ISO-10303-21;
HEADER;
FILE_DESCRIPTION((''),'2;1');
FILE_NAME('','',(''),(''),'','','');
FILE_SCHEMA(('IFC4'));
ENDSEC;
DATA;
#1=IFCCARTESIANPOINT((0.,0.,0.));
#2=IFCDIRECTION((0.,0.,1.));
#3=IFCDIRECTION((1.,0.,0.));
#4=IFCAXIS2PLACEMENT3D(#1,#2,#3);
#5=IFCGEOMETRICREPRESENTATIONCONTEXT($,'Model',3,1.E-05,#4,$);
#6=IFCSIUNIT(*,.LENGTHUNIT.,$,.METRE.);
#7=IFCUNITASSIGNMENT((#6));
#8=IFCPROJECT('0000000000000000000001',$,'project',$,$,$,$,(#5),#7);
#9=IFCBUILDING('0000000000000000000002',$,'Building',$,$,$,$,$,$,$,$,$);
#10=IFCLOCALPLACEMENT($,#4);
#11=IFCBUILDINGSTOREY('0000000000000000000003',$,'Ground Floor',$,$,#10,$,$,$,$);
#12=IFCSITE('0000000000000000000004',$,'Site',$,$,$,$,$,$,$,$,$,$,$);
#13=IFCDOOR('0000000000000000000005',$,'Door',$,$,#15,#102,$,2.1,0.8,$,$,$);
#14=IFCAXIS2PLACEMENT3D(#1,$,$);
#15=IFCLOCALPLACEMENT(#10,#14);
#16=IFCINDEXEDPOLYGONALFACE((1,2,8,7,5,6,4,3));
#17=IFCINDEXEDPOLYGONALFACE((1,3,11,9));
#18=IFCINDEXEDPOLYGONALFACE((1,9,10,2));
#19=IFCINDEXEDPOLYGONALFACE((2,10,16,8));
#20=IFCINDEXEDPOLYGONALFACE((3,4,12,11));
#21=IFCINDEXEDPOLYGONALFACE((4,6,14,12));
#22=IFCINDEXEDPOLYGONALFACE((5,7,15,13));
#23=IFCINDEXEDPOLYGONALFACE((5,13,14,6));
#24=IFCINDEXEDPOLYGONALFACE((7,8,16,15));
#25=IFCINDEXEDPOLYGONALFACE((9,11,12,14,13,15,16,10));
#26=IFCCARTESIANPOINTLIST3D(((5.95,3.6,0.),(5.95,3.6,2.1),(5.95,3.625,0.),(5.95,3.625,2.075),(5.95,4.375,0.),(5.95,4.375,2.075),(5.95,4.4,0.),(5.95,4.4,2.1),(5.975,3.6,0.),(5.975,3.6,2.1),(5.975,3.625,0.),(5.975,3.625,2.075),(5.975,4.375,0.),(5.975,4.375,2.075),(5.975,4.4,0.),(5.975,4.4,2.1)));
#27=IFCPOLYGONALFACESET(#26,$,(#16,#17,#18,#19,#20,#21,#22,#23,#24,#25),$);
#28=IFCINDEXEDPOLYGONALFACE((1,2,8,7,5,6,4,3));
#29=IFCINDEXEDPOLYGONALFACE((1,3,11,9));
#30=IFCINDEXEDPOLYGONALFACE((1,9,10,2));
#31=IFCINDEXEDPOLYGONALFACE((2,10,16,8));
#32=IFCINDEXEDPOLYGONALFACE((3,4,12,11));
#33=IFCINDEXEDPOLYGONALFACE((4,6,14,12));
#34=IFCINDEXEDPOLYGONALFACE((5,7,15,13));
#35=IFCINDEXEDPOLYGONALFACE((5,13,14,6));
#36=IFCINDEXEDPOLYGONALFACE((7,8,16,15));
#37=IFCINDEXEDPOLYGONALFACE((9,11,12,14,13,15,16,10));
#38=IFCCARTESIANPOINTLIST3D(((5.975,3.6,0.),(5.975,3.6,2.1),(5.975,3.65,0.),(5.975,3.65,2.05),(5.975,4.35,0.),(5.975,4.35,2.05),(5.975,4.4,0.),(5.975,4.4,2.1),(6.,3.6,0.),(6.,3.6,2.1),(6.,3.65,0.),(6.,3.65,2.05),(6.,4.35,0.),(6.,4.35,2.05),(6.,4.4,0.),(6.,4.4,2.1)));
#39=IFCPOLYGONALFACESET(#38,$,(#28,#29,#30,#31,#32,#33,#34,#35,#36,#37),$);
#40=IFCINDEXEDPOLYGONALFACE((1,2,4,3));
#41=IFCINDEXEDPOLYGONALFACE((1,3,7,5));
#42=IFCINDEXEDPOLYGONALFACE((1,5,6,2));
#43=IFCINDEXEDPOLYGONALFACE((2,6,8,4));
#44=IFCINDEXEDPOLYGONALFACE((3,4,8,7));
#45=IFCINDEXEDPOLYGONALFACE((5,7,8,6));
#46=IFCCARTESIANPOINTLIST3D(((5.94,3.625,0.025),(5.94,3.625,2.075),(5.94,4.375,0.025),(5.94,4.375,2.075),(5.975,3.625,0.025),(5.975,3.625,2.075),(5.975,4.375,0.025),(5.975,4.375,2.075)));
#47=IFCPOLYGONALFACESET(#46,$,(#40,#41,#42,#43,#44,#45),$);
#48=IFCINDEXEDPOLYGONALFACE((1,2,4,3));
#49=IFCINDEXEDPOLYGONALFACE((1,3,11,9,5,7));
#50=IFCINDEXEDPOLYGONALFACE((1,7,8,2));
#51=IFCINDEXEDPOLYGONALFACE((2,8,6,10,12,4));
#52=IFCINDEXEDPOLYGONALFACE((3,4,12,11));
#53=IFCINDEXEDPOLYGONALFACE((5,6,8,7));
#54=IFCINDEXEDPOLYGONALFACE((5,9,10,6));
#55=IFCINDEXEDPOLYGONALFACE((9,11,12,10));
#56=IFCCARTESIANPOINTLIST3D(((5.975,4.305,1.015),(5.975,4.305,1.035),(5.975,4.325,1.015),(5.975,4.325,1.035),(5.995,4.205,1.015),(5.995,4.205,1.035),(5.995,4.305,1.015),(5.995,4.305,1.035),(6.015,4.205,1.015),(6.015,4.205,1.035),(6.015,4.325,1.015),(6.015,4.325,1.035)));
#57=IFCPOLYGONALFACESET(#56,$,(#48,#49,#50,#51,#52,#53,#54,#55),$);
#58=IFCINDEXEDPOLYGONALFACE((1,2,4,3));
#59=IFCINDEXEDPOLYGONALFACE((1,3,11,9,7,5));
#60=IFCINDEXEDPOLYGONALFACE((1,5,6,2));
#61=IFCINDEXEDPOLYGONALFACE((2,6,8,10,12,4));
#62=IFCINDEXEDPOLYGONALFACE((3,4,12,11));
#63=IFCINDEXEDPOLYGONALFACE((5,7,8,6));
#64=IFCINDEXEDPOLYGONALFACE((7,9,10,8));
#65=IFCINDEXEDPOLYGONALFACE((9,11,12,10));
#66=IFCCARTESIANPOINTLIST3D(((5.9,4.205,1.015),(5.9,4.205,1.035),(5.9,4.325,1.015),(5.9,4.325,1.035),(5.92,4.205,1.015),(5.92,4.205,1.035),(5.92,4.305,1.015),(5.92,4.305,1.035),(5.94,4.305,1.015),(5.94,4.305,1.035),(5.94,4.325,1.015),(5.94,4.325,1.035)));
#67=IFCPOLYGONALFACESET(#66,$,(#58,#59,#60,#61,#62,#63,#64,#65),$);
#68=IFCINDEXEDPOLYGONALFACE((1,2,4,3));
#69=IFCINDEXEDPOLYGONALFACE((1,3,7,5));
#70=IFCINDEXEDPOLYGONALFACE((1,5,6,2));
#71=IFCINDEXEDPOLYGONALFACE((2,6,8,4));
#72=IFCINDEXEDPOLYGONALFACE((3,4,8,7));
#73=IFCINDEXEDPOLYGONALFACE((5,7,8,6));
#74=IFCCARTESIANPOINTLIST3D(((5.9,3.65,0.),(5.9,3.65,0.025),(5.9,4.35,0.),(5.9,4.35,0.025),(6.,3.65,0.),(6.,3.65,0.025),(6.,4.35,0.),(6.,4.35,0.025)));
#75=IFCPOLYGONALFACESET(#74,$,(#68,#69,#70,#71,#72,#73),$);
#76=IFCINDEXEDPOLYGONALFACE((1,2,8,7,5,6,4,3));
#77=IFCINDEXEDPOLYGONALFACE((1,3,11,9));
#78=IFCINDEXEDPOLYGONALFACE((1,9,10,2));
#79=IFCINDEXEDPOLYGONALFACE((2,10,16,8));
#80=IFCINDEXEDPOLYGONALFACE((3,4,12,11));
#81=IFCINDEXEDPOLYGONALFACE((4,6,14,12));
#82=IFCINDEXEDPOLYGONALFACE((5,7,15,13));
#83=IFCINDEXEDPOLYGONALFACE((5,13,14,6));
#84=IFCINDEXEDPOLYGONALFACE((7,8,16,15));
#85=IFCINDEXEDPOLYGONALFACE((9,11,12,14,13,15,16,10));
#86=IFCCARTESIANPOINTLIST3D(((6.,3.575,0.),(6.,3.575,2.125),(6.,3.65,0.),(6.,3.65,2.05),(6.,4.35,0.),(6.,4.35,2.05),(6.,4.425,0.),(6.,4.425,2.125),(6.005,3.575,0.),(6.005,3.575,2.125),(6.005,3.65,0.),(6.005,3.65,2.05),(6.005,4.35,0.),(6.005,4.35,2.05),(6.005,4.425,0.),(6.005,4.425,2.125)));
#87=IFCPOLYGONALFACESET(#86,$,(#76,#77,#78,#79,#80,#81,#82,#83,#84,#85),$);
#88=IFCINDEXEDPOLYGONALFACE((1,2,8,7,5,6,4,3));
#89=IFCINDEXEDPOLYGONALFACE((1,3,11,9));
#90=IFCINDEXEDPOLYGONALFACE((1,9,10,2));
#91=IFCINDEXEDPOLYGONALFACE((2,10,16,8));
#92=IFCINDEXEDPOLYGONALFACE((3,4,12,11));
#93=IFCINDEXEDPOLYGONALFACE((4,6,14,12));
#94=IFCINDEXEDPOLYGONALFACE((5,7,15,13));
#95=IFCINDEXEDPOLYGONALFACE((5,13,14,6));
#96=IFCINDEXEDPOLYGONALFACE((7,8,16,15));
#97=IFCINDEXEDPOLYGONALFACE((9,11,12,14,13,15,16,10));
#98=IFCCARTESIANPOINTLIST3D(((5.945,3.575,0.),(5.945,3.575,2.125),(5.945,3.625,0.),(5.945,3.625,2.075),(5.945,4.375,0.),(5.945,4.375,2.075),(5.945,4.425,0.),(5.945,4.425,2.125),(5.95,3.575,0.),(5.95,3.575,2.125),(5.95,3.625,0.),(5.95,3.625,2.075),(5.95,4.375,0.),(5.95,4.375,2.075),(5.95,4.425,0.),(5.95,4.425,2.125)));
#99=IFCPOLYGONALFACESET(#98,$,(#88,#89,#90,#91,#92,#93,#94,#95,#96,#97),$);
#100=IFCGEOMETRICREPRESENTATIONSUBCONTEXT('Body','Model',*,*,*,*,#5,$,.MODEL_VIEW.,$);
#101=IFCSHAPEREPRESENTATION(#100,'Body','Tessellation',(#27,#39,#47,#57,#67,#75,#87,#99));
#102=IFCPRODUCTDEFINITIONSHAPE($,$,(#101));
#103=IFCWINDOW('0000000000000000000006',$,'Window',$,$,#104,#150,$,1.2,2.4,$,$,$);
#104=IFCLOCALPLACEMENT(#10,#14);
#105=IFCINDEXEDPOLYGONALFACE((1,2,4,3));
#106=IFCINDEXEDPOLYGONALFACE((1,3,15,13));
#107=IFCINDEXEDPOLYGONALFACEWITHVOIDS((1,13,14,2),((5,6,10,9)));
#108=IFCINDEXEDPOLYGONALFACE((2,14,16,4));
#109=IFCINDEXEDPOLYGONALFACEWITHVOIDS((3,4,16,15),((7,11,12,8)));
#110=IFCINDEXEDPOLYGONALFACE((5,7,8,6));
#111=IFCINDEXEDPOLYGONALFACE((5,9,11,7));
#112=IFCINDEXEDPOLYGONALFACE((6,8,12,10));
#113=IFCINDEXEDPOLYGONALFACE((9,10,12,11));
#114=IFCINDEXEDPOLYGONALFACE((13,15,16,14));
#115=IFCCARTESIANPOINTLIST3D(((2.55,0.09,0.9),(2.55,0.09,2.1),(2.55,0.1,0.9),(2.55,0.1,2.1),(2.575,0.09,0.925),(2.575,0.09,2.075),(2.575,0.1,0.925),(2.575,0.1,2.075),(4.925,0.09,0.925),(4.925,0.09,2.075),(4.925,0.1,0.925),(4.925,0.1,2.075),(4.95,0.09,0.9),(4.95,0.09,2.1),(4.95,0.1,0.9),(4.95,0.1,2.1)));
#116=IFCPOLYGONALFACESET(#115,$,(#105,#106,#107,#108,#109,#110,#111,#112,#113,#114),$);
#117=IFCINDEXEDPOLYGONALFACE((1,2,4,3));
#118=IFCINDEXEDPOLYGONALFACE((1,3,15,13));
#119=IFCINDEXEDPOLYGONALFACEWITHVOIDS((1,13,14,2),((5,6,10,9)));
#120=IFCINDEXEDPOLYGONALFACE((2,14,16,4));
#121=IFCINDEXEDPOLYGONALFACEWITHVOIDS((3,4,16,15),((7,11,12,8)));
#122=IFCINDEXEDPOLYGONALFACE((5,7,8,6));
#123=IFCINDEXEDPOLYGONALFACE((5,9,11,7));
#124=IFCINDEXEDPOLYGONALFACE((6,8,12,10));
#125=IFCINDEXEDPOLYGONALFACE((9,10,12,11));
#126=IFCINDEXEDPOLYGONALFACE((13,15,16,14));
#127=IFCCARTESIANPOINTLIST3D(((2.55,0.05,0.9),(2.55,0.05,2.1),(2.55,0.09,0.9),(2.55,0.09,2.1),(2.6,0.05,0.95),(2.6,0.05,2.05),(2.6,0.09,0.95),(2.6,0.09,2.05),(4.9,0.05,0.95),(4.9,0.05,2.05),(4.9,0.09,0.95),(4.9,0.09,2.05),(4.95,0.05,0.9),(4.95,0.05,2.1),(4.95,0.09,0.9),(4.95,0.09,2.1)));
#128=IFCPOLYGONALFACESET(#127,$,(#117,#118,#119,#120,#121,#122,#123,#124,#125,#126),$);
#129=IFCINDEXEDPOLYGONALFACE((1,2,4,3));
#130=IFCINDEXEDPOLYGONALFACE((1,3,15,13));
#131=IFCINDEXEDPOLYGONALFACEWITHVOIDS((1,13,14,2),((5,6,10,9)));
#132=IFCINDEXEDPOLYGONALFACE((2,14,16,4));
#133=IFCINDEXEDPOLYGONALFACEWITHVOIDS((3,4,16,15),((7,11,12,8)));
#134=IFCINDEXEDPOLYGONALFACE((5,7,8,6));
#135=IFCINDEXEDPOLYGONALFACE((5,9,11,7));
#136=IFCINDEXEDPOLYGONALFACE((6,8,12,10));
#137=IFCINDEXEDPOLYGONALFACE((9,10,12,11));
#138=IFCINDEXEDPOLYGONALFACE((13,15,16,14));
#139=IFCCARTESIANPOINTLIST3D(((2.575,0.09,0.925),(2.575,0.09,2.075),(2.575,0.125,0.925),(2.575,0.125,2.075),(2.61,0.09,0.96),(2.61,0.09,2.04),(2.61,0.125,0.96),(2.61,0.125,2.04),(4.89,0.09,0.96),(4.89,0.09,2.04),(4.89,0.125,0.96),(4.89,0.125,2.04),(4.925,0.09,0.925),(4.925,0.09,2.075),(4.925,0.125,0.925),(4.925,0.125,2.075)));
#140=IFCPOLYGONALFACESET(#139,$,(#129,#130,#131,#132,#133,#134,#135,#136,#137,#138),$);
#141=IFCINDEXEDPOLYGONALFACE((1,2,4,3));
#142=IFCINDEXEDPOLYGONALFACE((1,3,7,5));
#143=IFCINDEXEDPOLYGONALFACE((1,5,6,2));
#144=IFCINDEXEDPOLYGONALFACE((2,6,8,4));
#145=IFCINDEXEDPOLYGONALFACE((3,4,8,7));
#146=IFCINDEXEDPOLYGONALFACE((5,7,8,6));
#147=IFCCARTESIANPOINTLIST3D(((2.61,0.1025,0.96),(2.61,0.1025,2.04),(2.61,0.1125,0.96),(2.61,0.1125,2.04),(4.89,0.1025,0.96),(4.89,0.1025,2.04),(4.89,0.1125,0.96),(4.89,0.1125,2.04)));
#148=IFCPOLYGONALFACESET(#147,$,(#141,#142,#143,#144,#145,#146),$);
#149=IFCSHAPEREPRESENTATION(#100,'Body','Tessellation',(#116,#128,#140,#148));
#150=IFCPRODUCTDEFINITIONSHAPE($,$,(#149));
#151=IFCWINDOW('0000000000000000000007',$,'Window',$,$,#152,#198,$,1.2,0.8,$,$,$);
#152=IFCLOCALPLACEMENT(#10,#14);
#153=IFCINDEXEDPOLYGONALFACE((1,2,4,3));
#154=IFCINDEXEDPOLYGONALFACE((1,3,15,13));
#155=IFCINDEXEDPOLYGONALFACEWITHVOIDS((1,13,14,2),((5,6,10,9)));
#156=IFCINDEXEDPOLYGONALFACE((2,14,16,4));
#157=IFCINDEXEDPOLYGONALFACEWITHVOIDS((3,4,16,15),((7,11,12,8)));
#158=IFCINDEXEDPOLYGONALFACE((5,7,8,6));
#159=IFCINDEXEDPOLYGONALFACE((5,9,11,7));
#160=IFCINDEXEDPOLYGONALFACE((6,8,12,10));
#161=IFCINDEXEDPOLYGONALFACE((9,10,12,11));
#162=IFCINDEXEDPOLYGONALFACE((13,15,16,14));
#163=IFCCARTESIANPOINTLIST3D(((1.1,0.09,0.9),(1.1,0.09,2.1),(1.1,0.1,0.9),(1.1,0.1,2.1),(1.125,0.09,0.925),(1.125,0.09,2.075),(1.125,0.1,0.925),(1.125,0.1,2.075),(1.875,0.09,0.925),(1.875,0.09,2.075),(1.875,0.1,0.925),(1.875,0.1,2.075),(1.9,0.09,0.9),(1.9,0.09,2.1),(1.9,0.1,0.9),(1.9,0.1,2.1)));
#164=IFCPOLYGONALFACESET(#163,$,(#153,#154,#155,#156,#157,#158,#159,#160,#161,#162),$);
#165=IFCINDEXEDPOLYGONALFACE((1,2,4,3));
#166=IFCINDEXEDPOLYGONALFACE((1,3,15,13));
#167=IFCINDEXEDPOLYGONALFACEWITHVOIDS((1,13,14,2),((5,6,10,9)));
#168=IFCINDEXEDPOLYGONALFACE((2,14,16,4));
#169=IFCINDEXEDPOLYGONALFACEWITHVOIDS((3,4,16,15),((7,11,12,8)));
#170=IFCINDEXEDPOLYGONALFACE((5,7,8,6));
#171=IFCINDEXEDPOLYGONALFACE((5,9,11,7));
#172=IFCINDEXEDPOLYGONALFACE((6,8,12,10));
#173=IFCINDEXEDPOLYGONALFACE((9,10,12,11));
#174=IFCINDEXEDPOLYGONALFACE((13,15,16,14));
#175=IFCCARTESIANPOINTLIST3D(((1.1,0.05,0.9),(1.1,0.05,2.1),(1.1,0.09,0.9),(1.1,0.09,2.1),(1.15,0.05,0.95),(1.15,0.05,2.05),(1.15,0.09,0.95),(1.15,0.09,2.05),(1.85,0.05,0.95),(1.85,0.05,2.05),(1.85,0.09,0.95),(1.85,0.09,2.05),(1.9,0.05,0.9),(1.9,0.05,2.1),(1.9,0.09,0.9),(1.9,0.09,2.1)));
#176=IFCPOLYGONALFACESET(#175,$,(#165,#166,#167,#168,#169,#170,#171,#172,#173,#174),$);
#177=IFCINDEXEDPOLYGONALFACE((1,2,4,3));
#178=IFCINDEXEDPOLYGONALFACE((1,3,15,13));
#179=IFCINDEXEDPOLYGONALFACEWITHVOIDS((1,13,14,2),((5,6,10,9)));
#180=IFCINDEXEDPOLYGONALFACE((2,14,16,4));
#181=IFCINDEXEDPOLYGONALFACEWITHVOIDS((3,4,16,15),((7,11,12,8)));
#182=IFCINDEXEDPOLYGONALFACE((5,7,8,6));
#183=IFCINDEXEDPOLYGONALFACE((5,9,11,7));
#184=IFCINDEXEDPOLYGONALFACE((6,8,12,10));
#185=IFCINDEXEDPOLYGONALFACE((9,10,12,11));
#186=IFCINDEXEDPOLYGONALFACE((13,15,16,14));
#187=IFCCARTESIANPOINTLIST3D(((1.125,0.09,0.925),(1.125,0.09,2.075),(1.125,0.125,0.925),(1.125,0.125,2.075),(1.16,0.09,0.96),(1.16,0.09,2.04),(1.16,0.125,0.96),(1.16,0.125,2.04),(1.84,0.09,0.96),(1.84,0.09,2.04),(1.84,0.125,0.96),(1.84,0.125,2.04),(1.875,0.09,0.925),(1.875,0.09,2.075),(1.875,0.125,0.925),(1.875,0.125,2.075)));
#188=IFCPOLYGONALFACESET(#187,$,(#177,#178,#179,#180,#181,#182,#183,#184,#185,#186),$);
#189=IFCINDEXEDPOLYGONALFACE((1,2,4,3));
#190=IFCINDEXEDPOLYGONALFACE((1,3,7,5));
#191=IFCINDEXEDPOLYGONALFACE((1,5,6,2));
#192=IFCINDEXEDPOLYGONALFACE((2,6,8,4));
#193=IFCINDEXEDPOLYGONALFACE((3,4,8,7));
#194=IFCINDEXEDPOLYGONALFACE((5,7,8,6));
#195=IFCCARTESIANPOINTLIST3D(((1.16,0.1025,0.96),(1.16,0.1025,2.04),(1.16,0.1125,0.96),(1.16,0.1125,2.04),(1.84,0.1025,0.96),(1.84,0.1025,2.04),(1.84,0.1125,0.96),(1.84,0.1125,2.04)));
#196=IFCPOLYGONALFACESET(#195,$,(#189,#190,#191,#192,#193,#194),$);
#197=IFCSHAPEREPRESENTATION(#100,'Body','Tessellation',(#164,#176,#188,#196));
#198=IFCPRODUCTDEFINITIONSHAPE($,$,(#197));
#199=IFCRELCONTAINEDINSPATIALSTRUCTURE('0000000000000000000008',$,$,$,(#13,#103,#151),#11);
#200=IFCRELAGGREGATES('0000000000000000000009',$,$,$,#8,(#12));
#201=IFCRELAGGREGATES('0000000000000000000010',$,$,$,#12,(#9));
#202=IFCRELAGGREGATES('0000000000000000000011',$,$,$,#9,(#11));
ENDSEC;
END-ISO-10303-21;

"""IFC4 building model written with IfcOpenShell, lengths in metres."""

from ifc_helpers import new_model, si_unit, frame, origin_with_axes, place, context, subcontext, project, spatial, line, indexed_curve, outline, extrude, element, save


model = new_model("IFC4")

# Units and contexts
model_context = context("Model", 3, precision=1e-05, world=origin_with_axes())
body_context = subcontext(model_context, "Body", "Model", "MODEL_VIEW")
ifc_project = project(units=[si_unit("LENGTHUNIT", "METRE")], contexts=[model_context])

# Site, building, storey
site = spatial("IfcSite", under=ifc_project, Name="Site")
building = spatial("IfcBuilding", under=site, Name="Building")
storey_placement = place(None, origin_with_axes())
storey = spatial("IfcBuildingStorey", under=building, at=storey_placement, Name="Ground Floor")

# Door
door_1_placement = place(storey_placement, frame((6.0, 3.6, 0.0), z_axis=(0.0, 0.0, 1.0), x_axis=(0.0, 1.0, 0.0)))
element("IfcDoor", 1, at=door_1_placement, inside=storey, Name="Door", OverallHeight=2.1, OverallWidth=0.8, context=body_context, shape_type="SweptSolid", body=[
    extrude(outline(indexed_curve([(0.0, 0.0), (0.0, 2.1), (0.8, 2.1), (0.8, 0.0), (0.775, 0.0), (0.775, 2.075), (0.025, 2.075), (0.025, 0.0)], segments=[line(1, 2, 3, 4, 5, 6, 7, 8, 1)])), frame((0.0, 0.025, 0.0), z_axis=(0.0, -1.0, 0.0), x_axis=(1.0, 0.0, 0.0)), (0.0, 0.0, -1.0), 0.025),
    extrude(outline(indexed_curve([(0.0, 0.0), (0.0, 2.1), (0.8, 2.1), (0.8, 0.0), (0.75, 0.0), (0.75, 2.05), (0.05, 2.05), (0.05, 0.0)], segments=[line(1, 2, 3, 4, 5, 6, 7, 8, 1)])), frame((0.0, 0.0, 0.0), z_axis=(0.0, -1.0, 0.0), x_axis=(1.0, 0.0, 0.0)), (0.0, 0.0, -1.0), 0.025),
    extrude(outline(indexed_curve([(0.0, 0.0), (0.75, 0.0), (0.75, 0.035), (0.0, 0.035)], segments=[line(1, 2, 3, 4, 1)])), frame((0.025, 0.025, 0.025), z_axis=(0.0, 0.0, 1.0), x_axis=(1.0, 0.0, 0.0)), (0.0, 0.0, 1.0), 2.05),
    extrude(outline(indexed_curve([(0.0, 0.0), (0.0, -0.04), (-0.12, -0.04), (-0.12, -0.02), (-0.02, -0.02), (-0.02, 0.0)], segments=[line(1, 2, 3, 4, 5, 6, 1)])), frame((0.725, 0.025, 1.015), z_axis=(0.0, 0.0, 1.0), x_axis=(1.0, 0.0, 0.0)), (0.0, 0.0, 1.0), 0.02),
    extrude(outline(indexed_curve([(0.0, 0.0), (0.0, 0.04), (-0.12, 0.04), (-0.12, 0.02), (-0.02, 0.02), (-0.02, 0.0)], segments=[line(1, 2, 3, 4, 5, 6, 1)])), frame((0.725, 0.06, 1.015), z_axis=(0.0, 0.0, 1.0), x_axis=(1.0, 0.0, 0.0)), (0.0, 0.0, 1.0), 0.02),
    extrude(outline(indexed_curve([(0.0, 0.0), (0.7, 0.0), (0.7, 0.1), (0.0, 0.1)], segments=[line(1, 2, 3, 4, 1)])), frame((0.05, 0.0, 0.0), z_axis=(0.0, 0.0, 1.0), x_axis=(1.0, 0.0, 0.0)), (0.0, 0.0, 1.0), 0.025),
    extrude(outline(indexed_curve([(0.0, 0.0), (0.0, 2.125), (0.85, 2.125), (0.85, 0.0), (0.775, 0.0), (0.775, 2.05), (0.075, 2.05), (0.075, 0.0)], segments=[line(1, 2, 3, 4, 5, 6, 7, 8, 1)])), frame((-0.025, -0.005, 0.0), z_axis=(0.0, -1.0, 0.0), x_axis=(1.0, 0.0, 0.0)), (0.0, 0.0, -1.0), 0.005),
    extrude(outline(indexed_curve([(0.0, 0.0), (0.0, 2.125), (0.85, 2.125), (0.85, 0.0), (0.8, 0.0), (0.8, 2.075), (0.05, 2.075), (0.05, 0.0)], segments=[line(1, 2, 3, 4, 5, 6, 7, 8, 1)])), frame((-0.025, 0.05, 0.0), z_axis=(0.0, -1.0, 0.0), x_axis=(1.0, 0.0, 0.0)), (0.0, 0.0, -1.0), 0.005),
])

# Windows
window_1_placement = place(storey_placement, frame((2.55, 0.0, 0.9), z_axis=(0.0, 0.0, 1.0), x_axis=(1.0, 0.0, 0.0)))
element("IfcWindow", 2, at=window_1_placement, inside=storey, Name="Window", OverallHeight=1.2, OverallWidth=2.4, context=body_context, shape_type="SweptSolid", body=[
    extrude(outline(indexed_curve([(0.0, 0.0), (2.4, 0.0), (2.4, 1.2), (0.0, 1.2)], segments=[line(1, 2, 3, 4, 1)]), holes=[indexed_curve([(0.025, 0.025), (2.375, 0.025), (2.375, 1.175), (0.025, 1.175)], segments=[line(1, 2, 3, 4, 1)])]), frame((0.0, 0.09, 0.0), z_axis=(0.0, -1.0, 0.0), x_axis=(1.0, 0.0, 0.0)), (0.0, 0.0, -1.0), 0.01),
    extrude(outline(indexed_curve([(0.0, 0.0), (2.4, 0.0), (2.4, 1.2), (0.0, 1.2)], segments=[line(1, 2, 3, 4, 1)]), holes=[indexed_curve([(0.05, 0.05), (2.35, 0.05), (2.35, 1.15), (0.05, 1.15)], segments=[line(1, 2, 3, 4, 1)])]), frame((0.0, 0.05, 0.0), z_axis=(0.0, -1.0, 0.0), x_axis=(1.0, 0.0, 0.0)), (0.0, 0.0, -1.0), 0.04),
    extrude(outline(indexed_curve([(0.0, 0.0), (2.35, 0.0), (2.35, 1.15), (0.0, 1.15)], segments=[line(1, 2, 3, 4, 1)]), holes=[indexed_curve([(0.035, 0.035), (2.315, 0.035), (2.315, 1.115), (0.035, 1.115)], segments=[line(1, 2, 3, 4, 1)])]), frame((0.025, 0.09, 0.025), z_axis=(0.0, -1.0, 0.0), x_axis=(1.0, 0.0, 0.0)), (0.0, 0.0, -1.0), 0.035),
    extrude(outline(indexed_curve([(0.035, 0.035), (2.315, 0.035), (2.315, 1.115), (0.035, 1.115)], segments=[line(1, 2, 3, 4, 1)])), frame((0.025, 0.1025, 0.025), z_axis=(0.0, -1.0, 0.0), x_axis=(1.0, 0.0, 0.0)), (0.0, 0.0, -1.0), 0.01),
])
window_2_placement = place(storey_placement, frame((1.1, 0.0, 0.9), z_axis=(0.0, 0.0, 1.0), x_axis=(1.0, 0.0, 0.0)))
element("IfcWindow", 3, at=window_2_placement, inside=storey, Name="Window", OverallHeight=1.2, OverallWidth=0.8, context=body_context, shape_type="SweptSolid", body=[
    extrude(outline(indexed_curve([(0.0, 0.0), (0.8, 0.0), (0.8, 1.2), (0.0, 1.2)], segments=[line(1, 2, 3, 4, 1)]), holes=[indexed_curve([(0.025, 0.025), (0.775, 0.025), (0.775, 1.175), (0.025, 1.175)], segments=[line(1, 2, 3, 4, 1)])]), frame((0.0, 0.09, 0.0), z_axis=(0.0, -1.0, 0.0), x_axis=(1.0, 0.0, 0.0)), (0.0, 0.0, -1.0), 0.01),
    extrude(outline(indexed_curve([(0.0, 0.0), (0.8, 0.0), (0.8, 1.2), (0.0, 1.2)], segments=[line(1, 2, 3, 4, 1)]), holes=[indexed_curve([(0.05, 0.05), (0.75, 0.05), (0.75, 1.15), (0.05, 1.15)], segments=[line(1, 2, 3, 4, 1)])]), frame((0.0, 0.05, 0.0), z_axis=(0.0, -1.0, 0.0), x_axis=(1.0, 0.0, 0.0)), (0.0, 0.0, -1.0), 0.04),
    extrude(outline(indexed_curve([(0.0, 0.0), (0.75, 0.0), (0.75, 1.15), (0.0, 1.15)], segments=[line(1, 2, 3, 4, 1)]), holes=[indexed_curve([(0.035, 0.035), (0.715, 0.035), (0.715, 1.115), (0.035, 1.115)], segments=[line(1, 2, 3, 4, 1)])]), frame((0.025, 0.09, 0.025), z_axis=(0.0, -1.0, 0.0), x_axis=(1.0, 0.0, 0.0)), (0.0, 0.0, -1.0), 0.035),
    extrude(outline(indexed_curve([(0.035, 0.035), (0.715, 0.035), (0.715, 1.115), (0.035, 1.115)], segments=[line(1, 2, 3, 4, 1)])), frame((0.025, 0.1025, 0.025), z_axis=(0.0, -1.0, 0.0), x_axis=(1.0, 0.0, 0.0)), (0.0, 0.0, -1.0), 0.01),
])

save(model, "model.ifc")
